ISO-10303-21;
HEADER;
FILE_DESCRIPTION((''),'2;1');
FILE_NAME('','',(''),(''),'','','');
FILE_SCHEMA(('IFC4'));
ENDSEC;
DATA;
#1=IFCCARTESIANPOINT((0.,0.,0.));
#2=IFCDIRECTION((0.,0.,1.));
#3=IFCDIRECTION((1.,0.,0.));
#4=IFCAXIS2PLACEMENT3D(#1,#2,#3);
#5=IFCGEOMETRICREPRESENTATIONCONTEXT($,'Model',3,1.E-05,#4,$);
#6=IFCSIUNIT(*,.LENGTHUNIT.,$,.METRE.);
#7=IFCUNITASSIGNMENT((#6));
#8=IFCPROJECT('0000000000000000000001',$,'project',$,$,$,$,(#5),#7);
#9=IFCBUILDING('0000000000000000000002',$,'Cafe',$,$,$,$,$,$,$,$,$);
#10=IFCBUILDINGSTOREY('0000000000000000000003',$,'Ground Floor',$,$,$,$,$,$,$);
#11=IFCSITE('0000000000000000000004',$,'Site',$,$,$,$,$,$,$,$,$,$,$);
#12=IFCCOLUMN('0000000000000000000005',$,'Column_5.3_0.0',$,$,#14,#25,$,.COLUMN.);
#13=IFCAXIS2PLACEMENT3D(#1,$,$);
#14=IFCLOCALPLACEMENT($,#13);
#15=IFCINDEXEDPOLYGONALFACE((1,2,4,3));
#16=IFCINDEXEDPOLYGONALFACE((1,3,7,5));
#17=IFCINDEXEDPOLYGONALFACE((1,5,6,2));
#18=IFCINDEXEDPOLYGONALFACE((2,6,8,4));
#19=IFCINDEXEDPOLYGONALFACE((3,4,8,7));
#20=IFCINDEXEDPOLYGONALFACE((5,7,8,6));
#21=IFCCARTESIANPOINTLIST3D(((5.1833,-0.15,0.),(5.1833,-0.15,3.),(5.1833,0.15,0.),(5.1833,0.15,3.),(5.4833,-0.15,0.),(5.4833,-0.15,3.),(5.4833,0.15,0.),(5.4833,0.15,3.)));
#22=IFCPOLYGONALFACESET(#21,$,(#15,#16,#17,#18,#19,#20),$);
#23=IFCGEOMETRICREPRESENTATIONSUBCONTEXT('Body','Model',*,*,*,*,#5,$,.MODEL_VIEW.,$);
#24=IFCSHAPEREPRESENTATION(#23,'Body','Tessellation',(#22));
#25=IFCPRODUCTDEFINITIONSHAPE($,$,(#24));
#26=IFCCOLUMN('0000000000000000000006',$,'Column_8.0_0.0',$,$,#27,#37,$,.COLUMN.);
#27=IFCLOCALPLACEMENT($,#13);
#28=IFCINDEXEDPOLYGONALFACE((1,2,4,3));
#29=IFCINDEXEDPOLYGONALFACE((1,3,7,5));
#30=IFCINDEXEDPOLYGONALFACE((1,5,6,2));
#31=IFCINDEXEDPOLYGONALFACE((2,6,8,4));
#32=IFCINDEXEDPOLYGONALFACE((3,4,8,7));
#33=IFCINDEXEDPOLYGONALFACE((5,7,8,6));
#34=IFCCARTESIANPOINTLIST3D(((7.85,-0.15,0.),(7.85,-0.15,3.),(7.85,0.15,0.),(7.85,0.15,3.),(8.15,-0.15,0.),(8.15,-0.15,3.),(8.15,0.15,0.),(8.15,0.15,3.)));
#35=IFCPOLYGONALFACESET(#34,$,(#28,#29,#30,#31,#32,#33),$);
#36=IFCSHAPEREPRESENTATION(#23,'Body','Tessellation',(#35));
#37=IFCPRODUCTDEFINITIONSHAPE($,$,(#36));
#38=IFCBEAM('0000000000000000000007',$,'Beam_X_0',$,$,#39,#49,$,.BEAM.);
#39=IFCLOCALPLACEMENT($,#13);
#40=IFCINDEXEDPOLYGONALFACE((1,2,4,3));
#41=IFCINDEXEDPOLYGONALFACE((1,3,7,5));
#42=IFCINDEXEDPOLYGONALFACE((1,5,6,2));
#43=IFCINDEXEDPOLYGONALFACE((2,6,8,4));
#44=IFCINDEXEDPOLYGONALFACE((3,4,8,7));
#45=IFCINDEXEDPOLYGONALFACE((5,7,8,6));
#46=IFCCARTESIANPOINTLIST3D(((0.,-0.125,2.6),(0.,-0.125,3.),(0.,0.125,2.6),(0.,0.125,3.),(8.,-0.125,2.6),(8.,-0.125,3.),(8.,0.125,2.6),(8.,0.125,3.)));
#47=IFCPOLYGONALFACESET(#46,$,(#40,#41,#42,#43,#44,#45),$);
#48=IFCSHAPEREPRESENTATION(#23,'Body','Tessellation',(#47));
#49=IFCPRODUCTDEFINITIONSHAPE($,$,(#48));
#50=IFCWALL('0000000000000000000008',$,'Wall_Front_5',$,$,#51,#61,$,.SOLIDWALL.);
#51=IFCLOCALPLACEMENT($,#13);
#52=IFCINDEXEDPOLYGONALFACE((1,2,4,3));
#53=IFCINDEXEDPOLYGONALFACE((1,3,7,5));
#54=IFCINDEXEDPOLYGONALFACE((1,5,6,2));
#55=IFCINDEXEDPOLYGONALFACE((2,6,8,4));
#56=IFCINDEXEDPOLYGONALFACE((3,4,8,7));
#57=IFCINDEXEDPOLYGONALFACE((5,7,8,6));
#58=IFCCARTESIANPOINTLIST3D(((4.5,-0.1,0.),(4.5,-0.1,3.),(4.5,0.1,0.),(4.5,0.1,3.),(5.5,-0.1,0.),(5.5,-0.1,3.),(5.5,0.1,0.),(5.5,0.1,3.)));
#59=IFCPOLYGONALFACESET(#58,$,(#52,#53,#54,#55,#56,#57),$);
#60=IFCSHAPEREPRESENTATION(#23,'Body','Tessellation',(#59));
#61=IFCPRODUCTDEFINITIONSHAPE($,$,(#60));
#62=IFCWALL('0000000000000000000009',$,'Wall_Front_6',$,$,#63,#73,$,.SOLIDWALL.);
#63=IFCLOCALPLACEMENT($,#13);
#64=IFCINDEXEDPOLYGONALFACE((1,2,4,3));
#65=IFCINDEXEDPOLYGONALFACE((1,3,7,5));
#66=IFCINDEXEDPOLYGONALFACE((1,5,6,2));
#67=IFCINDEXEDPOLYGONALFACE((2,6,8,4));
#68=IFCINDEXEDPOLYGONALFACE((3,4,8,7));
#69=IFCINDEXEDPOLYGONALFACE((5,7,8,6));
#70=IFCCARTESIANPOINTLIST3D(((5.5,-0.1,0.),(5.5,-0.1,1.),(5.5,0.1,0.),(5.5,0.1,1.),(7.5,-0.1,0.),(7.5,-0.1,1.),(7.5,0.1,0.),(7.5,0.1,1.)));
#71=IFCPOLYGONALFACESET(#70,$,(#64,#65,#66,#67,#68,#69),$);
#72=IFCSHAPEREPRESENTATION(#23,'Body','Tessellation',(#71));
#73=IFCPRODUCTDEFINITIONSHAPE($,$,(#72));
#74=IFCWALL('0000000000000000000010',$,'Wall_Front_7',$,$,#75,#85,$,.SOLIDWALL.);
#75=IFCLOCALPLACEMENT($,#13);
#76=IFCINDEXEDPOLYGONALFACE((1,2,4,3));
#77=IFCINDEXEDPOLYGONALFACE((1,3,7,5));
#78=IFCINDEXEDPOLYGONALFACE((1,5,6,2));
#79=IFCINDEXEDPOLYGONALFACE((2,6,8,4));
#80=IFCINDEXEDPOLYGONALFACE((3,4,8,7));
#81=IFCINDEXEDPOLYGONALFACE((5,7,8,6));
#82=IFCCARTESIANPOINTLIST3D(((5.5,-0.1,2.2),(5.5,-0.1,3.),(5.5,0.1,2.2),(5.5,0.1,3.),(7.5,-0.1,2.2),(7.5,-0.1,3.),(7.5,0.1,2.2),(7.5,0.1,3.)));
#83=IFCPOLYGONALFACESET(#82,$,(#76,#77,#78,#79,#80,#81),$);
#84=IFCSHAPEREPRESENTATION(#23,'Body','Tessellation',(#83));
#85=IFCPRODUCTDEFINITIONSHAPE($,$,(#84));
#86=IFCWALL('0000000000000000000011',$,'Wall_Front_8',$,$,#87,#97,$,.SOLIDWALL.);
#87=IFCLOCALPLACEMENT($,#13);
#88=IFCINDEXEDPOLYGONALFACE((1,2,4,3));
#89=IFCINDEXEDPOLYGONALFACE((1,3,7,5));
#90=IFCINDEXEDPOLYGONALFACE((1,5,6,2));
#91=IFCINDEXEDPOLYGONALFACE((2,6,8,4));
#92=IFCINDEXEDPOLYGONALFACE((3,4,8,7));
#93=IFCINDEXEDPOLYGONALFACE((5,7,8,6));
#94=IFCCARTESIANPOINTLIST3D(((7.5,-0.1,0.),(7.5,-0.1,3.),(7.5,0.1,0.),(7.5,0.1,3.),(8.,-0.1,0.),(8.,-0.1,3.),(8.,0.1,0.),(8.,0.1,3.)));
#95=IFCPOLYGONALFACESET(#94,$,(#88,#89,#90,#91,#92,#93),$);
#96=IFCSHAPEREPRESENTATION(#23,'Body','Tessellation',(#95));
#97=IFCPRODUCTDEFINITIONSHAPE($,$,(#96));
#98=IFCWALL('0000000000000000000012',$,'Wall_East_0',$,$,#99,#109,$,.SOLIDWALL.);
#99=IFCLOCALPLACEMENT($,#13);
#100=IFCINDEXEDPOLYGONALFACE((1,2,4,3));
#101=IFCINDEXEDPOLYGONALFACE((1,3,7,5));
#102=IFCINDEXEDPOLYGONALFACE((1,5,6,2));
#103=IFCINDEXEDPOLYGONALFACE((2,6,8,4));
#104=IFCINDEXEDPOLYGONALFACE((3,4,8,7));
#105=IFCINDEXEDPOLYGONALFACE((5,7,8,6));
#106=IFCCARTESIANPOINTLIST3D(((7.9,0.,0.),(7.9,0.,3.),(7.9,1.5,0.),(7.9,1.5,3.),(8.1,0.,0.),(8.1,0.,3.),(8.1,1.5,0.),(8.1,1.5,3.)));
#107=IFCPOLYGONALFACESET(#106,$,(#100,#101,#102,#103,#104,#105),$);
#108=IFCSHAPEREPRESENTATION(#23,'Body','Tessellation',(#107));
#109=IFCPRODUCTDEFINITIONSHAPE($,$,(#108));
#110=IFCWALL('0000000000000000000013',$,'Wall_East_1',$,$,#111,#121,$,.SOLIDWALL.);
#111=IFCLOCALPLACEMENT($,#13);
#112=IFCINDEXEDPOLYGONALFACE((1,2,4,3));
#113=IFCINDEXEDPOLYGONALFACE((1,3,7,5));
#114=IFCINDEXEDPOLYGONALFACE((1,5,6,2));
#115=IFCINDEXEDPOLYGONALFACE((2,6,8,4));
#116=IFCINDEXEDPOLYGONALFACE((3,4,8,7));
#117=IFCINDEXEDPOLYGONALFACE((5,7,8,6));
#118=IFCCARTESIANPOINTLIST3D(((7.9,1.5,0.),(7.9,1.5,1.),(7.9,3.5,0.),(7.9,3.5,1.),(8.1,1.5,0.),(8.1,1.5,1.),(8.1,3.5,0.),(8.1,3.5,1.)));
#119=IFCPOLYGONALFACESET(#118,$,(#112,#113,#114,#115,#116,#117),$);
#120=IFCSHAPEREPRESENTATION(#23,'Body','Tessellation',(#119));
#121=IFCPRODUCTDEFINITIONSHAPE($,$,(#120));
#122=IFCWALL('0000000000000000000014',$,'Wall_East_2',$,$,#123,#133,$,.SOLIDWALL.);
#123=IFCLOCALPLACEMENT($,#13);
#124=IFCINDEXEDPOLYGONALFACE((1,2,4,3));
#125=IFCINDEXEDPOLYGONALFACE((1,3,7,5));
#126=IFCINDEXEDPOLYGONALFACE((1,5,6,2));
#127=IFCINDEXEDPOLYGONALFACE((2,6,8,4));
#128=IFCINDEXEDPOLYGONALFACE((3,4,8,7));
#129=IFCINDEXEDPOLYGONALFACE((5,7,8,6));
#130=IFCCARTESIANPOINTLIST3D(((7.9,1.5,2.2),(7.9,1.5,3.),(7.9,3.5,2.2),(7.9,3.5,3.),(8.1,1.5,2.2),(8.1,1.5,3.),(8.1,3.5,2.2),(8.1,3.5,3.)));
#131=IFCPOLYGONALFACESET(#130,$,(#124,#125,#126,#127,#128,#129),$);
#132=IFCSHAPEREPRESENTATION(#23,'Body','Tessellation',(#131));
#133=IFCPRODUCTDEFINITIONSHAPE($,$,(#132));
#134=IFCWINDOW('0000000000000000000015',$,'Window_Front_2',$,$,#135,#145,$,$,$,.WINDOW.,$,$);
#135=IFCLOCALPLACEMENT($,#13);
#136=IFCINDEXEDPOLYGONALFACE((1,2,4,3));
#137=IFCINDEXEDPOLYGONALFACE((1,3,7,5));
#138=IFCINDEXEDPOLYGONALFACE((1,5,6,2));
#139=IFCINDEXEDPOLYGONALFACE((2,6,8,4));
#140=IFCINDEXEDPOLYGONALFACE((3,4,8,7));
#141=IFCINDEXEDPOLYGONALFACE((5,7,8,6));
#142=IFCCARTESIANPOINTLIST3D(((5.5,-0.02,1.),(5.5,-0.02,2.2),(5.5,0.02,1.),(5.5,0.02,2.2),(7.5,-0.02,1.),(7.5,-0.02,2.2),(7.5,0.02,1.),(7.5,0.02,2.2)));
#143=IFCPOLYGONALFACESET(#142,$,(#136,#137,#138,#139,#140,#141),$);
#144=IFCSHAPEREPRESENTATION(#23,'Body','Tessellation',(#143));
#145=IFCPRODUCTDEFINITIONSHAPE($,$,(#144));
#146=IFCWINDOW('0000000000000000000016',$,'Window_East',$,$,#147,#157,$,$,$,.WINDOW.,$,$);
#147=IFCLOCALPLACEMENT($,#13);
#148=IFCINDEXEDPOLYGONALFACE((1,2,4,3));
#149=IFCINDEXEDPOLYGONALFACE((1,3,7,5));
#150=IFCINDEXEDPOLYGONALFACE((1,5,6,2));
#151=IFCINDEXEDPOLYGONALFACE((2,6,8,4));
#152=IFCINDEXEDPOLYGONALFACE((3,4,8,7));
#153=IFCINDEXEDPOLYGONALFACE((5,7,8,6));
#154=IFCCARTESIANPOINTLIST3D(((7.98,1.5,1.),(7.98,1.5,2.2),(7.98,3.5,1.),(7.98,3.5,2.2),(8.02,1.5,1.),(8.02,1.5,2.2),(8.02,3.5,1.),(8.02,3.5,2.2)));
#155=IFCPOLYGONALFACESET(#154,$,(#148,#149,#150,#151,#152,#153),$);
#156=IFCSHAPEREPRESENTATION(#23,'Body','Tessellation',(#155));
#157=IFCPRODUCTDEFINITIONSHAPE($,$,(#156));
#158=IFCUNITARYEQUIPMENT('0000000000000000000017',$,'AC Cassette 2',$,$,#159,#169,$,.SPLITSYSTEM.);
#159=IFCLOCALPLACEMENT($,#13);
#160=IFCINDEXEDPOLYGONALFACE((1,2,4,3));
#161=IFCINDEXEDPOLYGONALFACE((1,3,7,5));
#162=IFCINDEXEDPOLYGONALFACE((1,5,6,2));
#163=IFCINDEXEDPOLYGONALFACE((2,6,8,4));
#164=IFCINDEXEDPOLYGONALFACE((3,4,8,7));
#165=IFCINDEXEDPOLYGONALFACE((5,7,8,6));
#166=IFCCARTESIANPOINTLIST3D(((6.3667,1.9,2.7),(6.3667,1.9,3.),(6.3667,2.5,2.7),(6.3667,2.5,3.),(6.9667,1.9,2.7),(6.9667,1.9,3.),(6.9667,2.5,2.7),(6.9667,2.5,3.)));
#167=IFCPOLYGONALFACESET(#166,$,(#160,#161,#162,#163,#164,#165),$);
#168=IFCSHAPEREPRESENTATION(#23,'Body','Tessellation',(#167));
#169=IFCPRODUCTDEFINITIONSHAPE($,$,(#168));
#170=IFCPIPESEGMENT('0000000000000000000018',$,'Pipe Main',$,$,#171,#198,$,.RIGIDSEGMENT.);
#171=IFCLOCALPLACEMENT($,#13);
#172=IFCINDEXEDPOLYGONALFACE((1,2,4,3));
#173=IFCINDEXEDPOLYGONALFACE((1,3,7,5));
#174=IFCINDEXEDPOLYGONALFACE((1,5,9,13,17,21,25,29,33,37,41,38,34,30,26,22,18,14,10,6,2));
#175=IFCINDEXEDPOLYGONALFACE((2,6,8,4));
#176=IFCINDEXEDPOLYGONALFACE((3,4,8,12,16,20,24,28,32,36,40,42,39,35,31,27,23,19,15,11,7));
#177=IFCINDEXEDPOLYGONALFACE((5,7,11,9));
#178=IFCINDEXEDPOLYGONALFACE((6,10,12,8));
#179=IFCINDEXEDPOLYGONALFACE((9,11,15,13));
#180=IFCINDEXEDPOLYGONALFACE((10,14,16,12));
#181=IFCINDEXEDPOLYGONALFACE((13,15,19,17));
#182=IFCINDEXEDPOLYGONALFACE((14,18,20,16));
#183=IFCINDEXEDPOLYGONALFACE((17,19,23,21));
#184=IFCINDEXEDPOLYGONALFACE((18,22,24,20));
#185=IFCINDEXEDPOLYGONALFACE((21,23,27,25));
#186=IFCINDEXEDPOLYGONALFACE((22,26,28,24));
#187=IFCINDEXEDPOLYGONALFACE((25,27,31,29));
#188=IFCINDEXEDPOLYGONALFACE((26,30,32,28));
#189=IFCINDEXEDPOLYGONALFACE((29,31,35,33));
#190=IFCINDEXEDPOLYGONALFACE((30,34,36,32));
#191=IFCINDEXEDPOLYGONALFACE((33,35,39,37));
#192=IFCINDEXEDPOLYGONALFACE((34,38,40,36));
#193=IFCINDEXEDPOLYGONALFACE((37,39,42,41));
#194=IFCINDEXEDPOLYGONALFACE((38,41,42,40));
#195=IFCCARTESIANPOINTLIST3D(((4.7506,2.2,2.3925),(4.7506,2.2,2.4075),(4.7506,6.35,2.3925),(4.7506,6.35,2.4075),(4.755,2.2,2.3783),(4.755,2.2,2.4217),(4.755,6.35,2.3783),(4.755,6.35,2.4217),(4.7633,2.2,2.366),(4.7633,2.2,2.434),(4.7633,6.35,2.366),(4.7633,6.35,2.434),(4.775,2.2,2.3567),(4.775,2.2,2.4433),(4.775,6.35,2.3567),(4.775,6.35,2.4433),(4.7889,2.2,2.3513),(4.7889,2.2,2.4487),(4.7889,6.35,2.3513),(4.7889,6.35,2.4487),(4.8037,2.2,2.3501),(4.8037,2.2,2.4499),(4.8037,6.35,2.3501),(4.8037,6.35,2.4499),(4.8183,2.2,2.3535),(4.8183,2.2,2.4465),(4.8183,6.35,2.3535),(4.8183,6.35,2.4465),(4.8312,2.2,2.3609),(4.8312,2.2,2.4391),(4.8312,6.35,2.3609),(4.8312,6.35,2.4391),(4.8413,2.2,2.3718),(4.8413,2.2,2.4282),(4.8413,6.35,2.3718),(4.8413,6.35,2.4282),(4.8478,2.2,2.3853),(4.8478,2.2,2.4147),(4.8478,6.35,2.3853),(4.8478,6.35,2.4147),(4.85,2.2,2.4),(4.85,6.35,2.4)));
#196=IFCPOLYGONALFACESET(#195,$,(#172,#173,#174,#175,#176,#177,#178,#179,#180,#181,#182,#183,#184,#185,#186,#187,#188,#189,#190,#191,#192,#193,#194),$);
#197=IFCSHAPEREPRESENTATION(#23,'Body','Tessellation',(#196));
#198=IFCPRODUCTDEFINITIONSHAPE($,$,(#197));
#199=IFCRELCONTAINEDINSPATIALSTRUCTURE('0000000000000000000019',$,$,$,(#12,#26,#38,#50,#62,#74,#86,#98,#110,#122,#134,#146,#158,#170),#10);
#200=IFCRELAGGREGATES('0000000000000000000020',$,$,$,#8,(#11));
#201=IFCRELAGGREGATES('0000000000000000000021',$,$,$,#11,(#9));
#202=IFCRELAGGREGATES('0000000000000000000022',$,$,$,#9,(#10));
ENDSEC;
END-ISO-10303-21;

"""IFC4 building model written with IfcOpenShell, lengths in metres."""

from ifc_helpers import new_model, si_unit, frame, origin, origin_with_axes, origin_2d, place, context, subcontext, project, spatial, rectangle, circle, extrude, element, save


model = new_model("IFC4")

# Units and contexts
model_context = context("Model", 3, precision=1e-05, world=origin_with_axes())
body_context = subcontext(model_context, "Body", "Model", "MODEL_VIEW")
ifc_project = project(units=[si_unit("LENGTHUNIT", "METRE")], contexts=[model_context])

# Site, building, storey
site = spatial("IfcSite", under=ifc_project, Name="Site")
building = spatial("IfcBuilding", under=site, Name="Cafe")
storey = spatial("IfcBuildingStorey", under=building, Name="Ground Floor")

# Columns
for number, where, z_axis, x_axis, name in (
    (1, (5.3333, 0.0, 0.0), (0.0, 0.0, 1.0), (1.0, 0.0, 0.0), "Column_5.3_0.0"),
    (2, (8.0, 0.0, 0.0), (0.0, 0.0, 1.0), (1.0, 0.0, 0.0), "Column_8.0_0.0"),
):
    element("IfcColumn", number, at=place(None, frame(where, z_axis=z_axis, x_axis=x_axis)), inside=storey, Name=name, PredefinedType="COLUMN", context=body_context, shape_type="SweptSolid", body=[
        extrude(rectangle(XDim=0.3, YDim=0.3, at=origin_2d()), origin(), (0.0, 0.0, 1.0), 3.0),
    ])

# Beam
beam_placement = place(None, frame((4.0, 0.0, 2.6), z_axis=(0.0, 0.0, 1.0), x_axis=(1.0, 0.0, 0.0)))
element("IfcBeam", 3, at=beam_placement, inside=storey, Name="Beam_X_0", PredefinedType="BEAM", context=body_context, shape_type="SweptSolid", body=[
    extrude(rectangle(XDim=8.0, YDim=0.25, at=origin_2d()), origin(), (0.0, 0.0, 1.0), 0.4),
])

# Walls
wall_1_placement = place(None, frame((5.0, 0.0, 0.0), z_axis=(0.0, 0.0, 1.0), x_axis=(1.0, 0.0, 0.0)))
element("IfcWall", 4, at=wall_1_placement, inside=storey, Name="Wall_Front_5", PredefinedType="SOLIDWALL", context=body_context, shape_type="SweptSolid", body=[
    extrude(rectangle(XDim=1.0, YDim=0.2, at=origin_2d()), origin(), (0.0, 0.0, 1.0), 3.0),
])
wall_2_placement = place(None, frame((6.5, 0.0, 0.0), z_axis=(0.0, 0.0, 1.0), x_axis=(1.0, 0.0, 0.0)))
element("IfcWall", 5, at=wall_2_placement, inside=storey, Name="Wall_Front_6", PredefinedType="SOLIDWALL", context=body_context, shape_type="SweptSolid", body=[
    extrude(rectangle(XDim=2.0, YDim=0.2, at=origin_2d()), origin(), (0.0, 0.0, 1.0), 1.0),
])
wall_3_placement = place(None, frame((6.5, 0.0, 2.2), z_axis=(0.0, 0.0, 1.0), x_axis=(1.0, 0.0, 0.0)))
element("IfcWall", 6, at=wall_3_placement, inside=storey, Name="Wall_Front_7", PredefinedType="SOLIDWALL", context=body_context, shape_type="SweptSolid", body=[
    extrude(rectangle(XDim=2.0, YDim=0.2, at=origin_2d()), origin(), (0.0, 0.0, 1.0), 0.8),
])
wall_4_placement = place(None, frame((7.75, 0.0, 0.0), z_axis=(0.0, 0.0, 1.0), x_axis=(1.0, 0.0, 0.0)))
element("IfcWall", 7, at=wall_4_placement, inside=storey, Name="Wall_Front_8", PredefinedType="SOLIDWALL", context=body_context, shape_type="SweptSolid", body=[
    extrude(rectangle(XDim=0.5, YDim=0.2, at=origin_2d()), origin(), (0.0, 0.0, 1.0), 3.0),
])
wall_5_placement = place(None, frame((8.0, 0.75, 0.0), z_axis=(0.0, 0.0, 1.0), x_axis=(1.0, 0.0, 0.0)))
element("IfcWall", 8, at=wall_5_placement, inside=storey, Name="Wall_East_0", PredefinedType="SOLIDWALL", context=body_context, shape_type="SweptSolid", body=[
    extrude(rectangle(XDim=0.2, YDim=1.5, at=origin_2d()), origin(), (0.0, 0.0, 1.0), 3.0),
])
wall_6_placement = place(None, frame((8.0, 2.5, 0.0), z_axis=(0.0, 0.0, 1.0), x_axis=(1.0, 0.0, 0.0)))
element("IfcWall", 9, at=wall_6_placement, inside=storey, Name="Wall_East_1", PredefinedType="SOLIDWALL", context=body_context, shape_type="SweptSolid", body=[
    extrude(rectangle(XDim=0.2, YDim=2.0, at=origin_2d()), origin(), (0.0, 0.0, 1.0), 1.0),
])
wall_7_placement = place(None, frame((8.0, 2.5, 2.2), z_axis=(0.0, 0.0, 1.0), x_axis=(1.0, 0.0, 0.0)))
element("IfcWall", 10, at=wall_7_placement, inside=storey, Name="Wall_East_2", PredefinedType="SOLIDWALL", context=body_context, shape_type="SweptSolid", body=[
    extrude(rectangle(XDim=0.2, YDim=2.0, at=origin_2d()), origin(), (0.0, 0.0, 1.0), 0.8),
])

# Windows
window_1_placement = place(None, frame((6.5, 0.0, 1.0), z_axis=(0.0, 0.0, 1.0), x_axis=(1.0, 0.0, 0.0)))
element("IfcWindow", 11, at=window_1_placement, inside=storey, Name="Window_Front_2", PredefinedType="WINDOW", context=body_context, shape_type="SweptSolid", body=[
    extrude(rectangle(XDim=2.0, YDim=0.04, at=origin_2d()), origin(), (0.0, 0.0, 1.0), 1.2),
])
window_2_placement = place(None, frame((8.0, 2.5, 1.0), z_axis=(0.0, 0.0, 1.0), x_axis=(1.0, 0.0, 0.0)))
element("IfcWindow", 12, at=window_2_placement, inside=storey, Name="Window_East", PredefinedType="WINDOW", context=body_context, shape_type="SweptSolid", body=[
    extrude(rectangle(XDim=0.04, YDim=2.0, at=origin_2d()), origin(), (0.0, 0.0, 1.0), 1.2),
])

# Unitary equipment
unitary_equipment_placement = place(None, frame((6.6667, 2.2, 2.7), z_axis=(0.0, 0.0, 1.0), x_axis=(1.0, 0.0, 0.0)))
element("IfcUnitaryEquipment", 13, at=unitary_equipment_placement, inside=storey, Name="AC Cassette 2", PredefinedType="SPLITSYSTEM", context=body_context, shape_type="SweptSolid", body=[
    extrude(rectangle(XDim=0.6, YDim=0.6, at=origin_2d()), origin(), (0.0, 0.0, 1.0), 0.3),
])

# Pipe segment
pipe_segment_1_placement = place(None, frame((4.8, 2.2, 2.4), z_axis=(0.0, 1.0, 0.0), x_axis=(1.0, 0.0, 0.0)))
element("IfcPipeSegment", 14, at=pipe_segment_1_placement, inside=storey, Name="Pipe Main", PredefinedType="RIGIDSEGMENT", context=body_context, shape_type="SweptSolid", body=[
    extrude(circle(Radius=0.05, at=origin_2d()), origin(), (0.0, 0.0, 1.0), 4.15),
])

save(model, "model.ifc")
